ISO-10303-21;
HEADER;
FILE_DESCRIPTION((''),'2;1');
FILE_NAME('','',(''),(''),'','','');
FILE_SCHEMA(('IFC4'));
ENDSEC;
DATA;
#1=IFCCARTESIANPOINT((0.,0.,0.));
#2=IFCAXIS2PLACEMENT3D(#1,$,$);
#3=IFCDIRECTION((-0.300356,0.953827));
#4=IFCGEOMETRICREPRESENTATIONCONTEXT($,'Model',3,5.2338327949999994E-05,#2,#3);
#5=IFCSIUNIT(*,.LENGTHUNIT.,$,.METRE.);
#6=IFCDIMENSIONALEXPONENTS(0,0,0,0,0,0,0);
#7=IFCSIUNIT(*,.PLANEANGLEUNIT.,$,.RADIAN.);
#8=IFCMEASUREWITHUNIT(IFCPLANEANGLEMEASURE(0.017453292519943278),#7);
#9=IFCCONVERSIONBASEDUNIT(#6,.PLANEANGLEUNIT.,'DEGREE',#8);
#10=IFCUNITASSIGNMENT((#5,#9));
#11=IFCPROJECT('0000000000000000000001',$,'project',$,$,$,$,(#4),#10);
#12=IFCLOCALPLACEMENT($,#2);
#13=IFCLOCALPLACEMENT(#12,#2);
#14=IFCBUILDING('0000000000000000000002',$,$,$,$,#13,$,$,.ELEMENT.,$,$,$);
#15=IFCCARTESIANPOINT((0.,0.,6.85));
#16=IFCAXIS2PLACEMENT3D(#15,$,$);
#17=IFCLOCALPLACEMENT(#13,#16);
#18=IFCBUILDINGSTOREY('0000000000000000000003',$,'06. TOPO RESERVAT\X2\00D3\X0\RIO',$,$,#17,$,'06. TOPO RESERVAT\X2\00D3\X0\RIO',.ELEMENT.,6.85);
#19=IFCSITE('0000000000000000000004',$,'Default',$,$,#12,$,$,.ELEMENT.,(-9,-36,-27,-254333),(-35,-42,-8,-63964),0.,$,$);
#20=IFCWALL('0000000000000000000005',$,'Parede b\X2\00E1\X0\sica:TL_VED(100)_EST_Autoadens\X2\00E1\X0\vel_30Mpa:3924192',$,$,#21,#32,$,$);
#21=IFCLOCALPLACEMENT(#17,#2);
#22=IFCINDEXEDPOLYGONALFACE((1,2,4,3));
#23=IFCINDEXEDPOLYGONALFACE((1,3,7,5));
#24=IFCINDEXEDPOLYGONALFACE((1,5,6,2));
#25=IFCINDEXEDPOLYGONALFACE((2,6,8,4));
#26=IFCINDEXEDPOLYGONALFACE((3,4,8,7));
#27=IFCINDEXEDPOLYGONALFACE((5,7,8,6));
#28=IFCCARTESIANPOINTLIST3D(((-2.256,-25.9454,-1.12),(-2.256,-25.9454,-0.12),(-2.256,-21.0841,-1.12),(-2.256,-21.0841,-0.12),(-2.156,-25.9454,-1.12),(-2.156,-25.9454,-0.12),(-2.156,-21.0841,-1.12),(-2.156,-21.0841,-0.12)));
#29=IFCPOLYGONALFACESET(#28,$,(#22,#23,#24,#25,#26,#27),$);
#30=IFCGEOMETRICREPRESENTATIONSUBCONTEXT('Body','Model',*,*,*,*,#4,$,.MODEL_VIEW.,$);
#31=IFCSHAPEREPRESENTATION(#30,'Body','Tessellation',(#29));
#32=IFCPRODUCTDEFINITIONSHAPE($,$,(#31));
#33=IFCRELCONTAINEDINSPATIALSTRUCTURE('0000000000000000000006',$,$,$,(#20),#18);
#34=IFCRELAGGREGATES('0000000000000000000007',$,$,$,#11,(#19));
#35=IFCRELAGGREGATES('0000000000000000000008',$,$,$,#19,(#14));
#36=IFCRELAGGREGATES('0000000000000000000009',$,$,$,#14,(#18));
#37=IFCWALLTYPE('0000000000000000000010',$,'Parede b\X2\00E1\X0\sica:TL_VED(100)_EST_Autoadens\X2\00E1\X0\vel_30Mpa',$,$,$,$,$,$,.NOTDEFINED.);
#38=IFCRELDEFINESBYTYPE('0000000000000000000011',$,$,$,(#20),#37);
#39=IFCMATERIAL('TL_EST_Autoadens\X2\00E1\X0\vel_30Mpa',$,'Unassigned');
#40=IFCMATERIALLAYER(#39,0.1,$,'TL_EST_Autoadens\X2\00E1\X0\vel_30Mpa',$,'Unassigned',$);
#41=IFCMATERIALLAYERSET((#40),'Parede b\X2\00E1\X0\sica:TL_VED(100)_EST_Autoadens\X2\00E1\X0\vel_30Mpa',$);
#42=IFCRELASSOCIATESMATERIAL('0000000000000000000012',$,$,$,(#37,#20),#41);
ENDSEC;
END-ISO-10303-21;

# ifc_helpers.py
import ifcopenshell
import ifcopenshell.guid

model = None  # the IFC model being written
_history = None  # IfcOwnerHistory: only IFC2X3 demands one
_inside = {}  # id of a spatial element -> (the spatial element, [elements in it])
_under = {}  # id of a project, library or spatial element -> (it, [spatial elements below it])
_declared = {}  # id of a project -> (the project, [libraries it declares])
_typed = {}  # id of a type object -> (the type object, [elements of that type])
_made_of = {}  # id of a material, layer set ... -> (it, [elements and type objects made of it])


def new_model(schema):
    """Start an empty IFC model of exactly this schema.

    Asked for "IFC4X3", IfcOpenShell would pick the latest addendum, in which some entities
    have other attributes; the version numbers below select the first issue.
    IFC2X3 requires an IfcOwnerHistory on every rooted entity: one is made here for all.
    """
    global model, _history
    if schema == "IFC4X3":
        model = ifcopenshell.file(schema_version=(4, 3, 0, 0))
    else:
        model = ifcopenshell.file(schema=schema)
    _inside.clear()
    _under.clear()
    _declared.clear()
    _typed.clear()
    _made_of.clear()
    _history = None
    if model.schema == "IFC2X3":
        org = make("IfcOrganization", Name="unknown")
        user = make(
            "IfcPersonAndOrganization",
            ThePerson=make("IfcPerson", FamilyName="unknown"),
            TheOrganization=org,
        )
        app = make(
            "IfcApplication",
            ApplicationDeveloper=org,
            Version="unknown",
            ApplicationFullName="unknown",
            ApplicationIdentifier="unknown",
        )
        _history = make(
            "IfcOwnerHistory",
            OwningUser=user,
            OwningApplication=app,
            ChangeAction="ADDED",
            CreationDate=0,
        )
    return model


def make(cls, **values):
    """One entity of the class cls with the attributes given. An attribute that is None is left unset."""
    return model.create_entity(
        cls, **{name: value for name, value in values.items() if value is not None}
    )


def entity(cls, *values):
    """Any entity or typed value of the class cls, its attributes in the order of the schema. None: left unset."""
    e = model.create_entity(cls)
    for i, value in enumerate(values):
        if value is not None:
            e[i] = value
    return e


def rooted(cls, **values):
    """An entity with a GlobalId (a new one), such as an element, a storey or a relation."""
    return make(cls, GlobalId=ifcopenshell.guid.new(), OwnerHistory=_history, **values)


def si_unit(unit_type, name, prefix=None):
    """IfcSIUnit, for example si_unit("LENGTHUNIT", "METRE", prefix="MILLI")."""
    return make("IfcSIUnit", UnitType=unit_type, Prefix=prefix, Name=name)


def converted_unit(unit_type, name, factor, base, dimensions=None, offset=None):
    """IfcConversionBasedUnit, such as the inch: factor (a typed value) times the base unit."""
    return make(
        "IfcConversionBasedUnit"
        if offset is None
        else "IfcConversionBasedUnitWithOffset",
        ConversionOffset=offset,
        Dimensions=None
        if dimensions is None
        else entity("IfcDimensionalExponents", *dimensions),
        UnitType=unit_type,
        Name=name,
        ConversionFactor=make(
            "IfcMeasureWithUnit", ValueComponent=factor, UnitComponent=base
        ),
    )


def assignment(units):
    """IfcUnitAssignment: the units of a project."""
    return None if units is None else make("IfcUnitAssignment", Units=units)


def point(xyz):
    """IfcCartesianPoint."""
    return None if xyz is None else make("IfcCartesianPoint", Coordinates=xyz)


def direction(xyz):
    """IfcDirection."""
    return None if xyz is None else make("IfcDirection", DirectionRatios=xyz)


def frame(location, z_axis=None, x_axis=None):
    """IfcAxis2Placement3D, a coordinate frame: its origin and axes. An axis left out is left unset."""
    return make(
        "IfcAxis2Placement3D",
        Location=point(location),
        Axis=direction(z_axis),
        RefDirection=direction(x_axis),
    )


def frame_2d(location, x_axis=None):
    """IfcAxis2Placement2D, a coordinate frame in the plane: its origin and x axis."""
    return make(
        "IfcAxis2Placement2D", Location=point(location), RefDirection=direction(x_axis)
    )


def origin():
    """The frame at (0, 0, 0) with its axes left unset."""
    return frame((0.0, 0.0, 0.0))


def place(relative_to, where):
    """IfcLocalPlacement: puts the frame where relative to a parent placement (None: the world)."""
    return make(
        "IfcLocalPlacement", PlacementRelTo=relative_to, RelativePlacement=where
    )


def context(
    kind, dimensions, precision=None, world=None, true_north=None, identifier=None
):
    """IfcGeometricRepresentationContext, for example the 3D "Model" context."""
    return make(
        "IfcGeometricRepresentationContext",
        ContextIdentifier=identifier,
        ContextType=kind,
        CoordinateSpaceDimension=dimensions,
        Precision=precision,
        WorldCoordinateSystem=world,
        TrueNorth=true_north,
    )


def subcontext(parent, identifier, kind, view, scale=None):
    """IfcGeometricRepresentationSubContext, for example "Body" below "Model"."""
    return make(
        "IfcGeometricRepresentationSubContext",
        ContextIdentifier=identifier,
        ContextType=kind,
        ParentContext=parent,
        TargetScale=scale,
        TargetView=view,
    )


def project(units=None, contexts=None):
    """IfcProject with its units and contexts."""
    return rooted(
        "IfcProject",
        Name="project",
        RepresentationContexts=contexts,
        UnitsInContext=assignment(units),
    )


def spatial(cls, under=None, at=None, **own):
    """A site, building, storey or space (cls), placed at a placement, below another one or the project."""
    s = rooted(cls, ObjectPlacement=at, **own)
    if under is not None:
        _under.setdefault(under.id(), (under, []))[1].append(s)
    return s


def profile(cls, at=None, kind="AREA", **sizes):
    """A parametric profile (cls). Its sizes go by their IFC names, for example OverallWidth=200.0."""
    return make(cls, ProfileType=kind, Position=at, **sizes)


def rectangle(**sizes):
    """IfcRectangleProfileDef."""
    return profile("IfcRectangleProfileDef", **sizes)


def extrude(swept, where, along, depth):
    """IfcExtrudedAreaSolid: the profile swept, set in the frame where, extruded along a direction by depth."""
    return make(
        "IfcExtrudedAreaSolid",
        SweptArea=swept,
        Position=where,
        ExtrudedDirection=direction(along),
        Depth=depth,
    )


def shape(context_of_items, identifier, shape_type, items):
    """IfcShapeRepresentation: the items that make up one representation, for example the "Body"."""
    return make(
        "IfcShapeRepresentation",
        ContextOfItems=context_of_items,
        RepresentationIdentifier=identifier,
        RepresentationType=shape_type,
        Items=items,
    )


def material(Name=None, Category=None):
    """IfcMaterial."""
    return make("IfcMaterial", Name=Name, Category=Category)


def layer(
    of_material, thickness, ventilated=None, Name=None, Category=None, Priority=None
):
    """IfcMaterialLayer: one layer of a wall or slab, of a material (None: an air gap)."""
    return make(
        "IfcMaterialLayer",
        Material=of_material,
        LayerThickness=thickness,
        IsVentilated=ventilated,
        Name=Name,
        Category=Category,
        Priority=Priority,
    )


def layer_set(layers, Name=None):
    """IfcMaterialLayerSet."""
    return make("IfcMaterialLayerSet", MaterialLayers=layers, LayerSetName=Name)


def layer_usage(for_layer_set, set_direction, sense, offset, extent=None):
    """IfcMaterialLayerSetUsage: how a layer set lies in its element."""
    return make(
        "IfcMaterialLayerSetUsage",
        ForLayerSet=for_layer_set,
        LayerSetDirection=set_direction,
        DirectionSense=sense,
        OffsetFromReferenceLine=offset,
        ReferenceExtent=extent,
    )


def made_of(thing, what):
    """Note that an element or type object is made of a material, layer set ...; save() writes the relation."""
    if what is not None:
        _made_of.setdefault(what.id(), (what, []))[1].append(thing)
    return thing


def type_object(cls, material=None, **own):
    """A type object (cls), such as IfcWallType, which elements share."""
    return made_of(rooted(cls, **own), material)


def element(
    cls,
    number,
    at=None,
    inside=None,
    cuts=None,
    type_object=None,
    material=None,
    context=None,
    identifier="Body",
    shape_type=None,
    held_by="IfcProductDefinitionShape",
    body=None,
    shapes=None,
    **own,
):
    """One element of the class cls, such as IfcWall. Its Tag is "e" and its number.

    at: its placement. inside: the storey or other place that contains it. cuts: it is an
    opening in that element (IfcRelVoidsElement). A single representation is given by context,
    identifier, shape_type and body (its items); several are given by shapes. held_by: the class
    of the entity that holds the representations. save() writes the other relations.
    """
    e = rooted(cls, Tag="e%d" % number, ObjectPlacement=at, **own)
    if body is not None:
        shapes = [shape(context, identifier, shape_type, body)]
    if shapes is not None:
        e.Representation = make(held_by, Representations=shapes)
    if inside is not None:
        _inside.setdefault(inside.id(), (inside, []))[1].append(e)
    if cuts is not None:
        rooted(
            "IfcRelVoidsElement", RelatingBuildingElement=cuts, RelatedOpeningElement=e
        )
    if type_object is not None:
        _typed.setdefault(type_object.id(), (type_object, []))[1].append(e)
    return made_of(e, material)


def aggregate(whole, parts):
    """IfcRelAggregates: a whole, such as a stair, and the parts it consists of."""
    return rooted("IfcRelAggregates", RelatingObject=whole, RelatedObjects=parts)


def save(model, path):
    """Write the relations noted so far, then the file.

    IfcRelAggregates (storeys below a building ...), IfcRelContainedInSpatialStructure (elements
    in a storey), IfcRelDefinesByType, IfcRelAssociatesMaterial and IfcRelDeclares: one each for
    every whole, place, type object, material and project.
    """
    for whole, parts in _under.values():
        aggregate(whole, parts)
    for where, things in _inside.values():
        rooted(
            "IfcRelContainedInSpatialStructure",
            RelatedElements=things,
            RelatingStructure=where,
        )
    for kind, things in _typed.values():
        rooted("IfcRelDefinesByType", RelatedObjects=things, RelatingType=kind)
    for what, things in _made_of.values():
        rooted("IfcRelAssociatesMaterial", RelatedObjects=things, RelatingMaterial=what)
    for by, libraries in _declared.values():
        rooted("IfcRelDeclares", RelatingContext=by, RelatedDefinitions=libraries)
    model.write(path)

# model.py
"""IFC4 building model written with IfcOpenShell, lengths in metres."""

from ifc_helpers import new_model, entity, si_unit, converted_unit, direction, frame, frame_2d, origin, place, context, subcontext, project, spatial, rectangle, extrude, material, layer, layer_set, layer_usage, type_object, element, save


model = new_model("IFC4")

# Units and contexts
model_context = context("Model", 3, precision=5.2338327949999994e-05, world=origin(), true_north=direction((-0.300356, 0.953827)))
body_context = subcontext(model_context, "Body", "Model", "MODEL_VIEW")
ifc_project = project(units=[si_unit("LENGTHUNIT", "METRE"), converted_unit("PLANEANGLEUNIT", "DEGREE", entity("IfcPlaneAngleMeasure", 0.017453292519943278), si_unit("PLANEANGLEUNIT", "RADIAN"), dimensions=[0, 0, 0, 0, 0, 0, 0])], contexts=[model_context])

# Site, building, storey
site_placement = place(None, origin())
site = spatial("IfcSite", under=ifc_project, at=site_placement, Name="Default", CompositionType="ELEMENT", RefLatitude=(-9, -36, -27, -254333), RefLongitude=(-35, -42, -8, -63964), RefElevation=0.0)
building_placement = place(site_placement, origin())
building = spatial("IfcBuilding", under=site, at=building_placement, CompositionType="ELEMENT")
storey_placement = place(building_placement, frame((0.0, 0.0, 6.85)))
storey = spatial("IfcBuildingStorey", under=building, at=storey_placement, Name="06. TOPO RESERVATÓRIO", LongName="06. TOPO RESERVATÓRIO", CompositionType="ELEMENT", Elevation=6.85)

# Wall
ifc_material_1 = material(Name="TL_EST_Autoadensável_30Mpa", Category="Unassigned")
ifc_layer = layer(ifc_material_1, 0.1, Name="TL_EST_Autoadensável_30Mpa", Category="Unassigned")
ifc_layer_set = layer_set([ifc_layer], Name="Parede básica:TL_VED(100)_EST_Autoadensável_30Mpa")
ifc_layer_usage = layer_usage(ifc_layer_set, "AXIS2", "NEGATIVE", 0.05)
wall_type = type_object("IfcWallType", Name="Parede básica:TL_VED(100)_EST_Autoadensável_30Mpa", PredefinedType="NOTDEFINED", material=ifc_layer_set)
wall_placement = place(storey_placement, frame((-2.206, -21.0841, -1.12), z_axis=(0.0, 0.0, 1.0), x_axis=(0.0, -1.0, 0.0)))
element("IfcWall", 1, at=wall_placement, inside=storey, type_object=wall_type, material=ifc_layer_usage, Name="Parede básica:TL_VED(100)_EST_Autoadensável_30Mpa:3924192", context=body_context, shape_type="SweptSolid", body=[
    extrude(rectangle(XDim=4.8613, YDim=0.1, at=frame_2d((2.4306, 0.0), x_axis=(-1.0, 0.0))), origin(), (0.0, 0.0, 1.0), 1.0),
])

save(model, "model.ifc")
